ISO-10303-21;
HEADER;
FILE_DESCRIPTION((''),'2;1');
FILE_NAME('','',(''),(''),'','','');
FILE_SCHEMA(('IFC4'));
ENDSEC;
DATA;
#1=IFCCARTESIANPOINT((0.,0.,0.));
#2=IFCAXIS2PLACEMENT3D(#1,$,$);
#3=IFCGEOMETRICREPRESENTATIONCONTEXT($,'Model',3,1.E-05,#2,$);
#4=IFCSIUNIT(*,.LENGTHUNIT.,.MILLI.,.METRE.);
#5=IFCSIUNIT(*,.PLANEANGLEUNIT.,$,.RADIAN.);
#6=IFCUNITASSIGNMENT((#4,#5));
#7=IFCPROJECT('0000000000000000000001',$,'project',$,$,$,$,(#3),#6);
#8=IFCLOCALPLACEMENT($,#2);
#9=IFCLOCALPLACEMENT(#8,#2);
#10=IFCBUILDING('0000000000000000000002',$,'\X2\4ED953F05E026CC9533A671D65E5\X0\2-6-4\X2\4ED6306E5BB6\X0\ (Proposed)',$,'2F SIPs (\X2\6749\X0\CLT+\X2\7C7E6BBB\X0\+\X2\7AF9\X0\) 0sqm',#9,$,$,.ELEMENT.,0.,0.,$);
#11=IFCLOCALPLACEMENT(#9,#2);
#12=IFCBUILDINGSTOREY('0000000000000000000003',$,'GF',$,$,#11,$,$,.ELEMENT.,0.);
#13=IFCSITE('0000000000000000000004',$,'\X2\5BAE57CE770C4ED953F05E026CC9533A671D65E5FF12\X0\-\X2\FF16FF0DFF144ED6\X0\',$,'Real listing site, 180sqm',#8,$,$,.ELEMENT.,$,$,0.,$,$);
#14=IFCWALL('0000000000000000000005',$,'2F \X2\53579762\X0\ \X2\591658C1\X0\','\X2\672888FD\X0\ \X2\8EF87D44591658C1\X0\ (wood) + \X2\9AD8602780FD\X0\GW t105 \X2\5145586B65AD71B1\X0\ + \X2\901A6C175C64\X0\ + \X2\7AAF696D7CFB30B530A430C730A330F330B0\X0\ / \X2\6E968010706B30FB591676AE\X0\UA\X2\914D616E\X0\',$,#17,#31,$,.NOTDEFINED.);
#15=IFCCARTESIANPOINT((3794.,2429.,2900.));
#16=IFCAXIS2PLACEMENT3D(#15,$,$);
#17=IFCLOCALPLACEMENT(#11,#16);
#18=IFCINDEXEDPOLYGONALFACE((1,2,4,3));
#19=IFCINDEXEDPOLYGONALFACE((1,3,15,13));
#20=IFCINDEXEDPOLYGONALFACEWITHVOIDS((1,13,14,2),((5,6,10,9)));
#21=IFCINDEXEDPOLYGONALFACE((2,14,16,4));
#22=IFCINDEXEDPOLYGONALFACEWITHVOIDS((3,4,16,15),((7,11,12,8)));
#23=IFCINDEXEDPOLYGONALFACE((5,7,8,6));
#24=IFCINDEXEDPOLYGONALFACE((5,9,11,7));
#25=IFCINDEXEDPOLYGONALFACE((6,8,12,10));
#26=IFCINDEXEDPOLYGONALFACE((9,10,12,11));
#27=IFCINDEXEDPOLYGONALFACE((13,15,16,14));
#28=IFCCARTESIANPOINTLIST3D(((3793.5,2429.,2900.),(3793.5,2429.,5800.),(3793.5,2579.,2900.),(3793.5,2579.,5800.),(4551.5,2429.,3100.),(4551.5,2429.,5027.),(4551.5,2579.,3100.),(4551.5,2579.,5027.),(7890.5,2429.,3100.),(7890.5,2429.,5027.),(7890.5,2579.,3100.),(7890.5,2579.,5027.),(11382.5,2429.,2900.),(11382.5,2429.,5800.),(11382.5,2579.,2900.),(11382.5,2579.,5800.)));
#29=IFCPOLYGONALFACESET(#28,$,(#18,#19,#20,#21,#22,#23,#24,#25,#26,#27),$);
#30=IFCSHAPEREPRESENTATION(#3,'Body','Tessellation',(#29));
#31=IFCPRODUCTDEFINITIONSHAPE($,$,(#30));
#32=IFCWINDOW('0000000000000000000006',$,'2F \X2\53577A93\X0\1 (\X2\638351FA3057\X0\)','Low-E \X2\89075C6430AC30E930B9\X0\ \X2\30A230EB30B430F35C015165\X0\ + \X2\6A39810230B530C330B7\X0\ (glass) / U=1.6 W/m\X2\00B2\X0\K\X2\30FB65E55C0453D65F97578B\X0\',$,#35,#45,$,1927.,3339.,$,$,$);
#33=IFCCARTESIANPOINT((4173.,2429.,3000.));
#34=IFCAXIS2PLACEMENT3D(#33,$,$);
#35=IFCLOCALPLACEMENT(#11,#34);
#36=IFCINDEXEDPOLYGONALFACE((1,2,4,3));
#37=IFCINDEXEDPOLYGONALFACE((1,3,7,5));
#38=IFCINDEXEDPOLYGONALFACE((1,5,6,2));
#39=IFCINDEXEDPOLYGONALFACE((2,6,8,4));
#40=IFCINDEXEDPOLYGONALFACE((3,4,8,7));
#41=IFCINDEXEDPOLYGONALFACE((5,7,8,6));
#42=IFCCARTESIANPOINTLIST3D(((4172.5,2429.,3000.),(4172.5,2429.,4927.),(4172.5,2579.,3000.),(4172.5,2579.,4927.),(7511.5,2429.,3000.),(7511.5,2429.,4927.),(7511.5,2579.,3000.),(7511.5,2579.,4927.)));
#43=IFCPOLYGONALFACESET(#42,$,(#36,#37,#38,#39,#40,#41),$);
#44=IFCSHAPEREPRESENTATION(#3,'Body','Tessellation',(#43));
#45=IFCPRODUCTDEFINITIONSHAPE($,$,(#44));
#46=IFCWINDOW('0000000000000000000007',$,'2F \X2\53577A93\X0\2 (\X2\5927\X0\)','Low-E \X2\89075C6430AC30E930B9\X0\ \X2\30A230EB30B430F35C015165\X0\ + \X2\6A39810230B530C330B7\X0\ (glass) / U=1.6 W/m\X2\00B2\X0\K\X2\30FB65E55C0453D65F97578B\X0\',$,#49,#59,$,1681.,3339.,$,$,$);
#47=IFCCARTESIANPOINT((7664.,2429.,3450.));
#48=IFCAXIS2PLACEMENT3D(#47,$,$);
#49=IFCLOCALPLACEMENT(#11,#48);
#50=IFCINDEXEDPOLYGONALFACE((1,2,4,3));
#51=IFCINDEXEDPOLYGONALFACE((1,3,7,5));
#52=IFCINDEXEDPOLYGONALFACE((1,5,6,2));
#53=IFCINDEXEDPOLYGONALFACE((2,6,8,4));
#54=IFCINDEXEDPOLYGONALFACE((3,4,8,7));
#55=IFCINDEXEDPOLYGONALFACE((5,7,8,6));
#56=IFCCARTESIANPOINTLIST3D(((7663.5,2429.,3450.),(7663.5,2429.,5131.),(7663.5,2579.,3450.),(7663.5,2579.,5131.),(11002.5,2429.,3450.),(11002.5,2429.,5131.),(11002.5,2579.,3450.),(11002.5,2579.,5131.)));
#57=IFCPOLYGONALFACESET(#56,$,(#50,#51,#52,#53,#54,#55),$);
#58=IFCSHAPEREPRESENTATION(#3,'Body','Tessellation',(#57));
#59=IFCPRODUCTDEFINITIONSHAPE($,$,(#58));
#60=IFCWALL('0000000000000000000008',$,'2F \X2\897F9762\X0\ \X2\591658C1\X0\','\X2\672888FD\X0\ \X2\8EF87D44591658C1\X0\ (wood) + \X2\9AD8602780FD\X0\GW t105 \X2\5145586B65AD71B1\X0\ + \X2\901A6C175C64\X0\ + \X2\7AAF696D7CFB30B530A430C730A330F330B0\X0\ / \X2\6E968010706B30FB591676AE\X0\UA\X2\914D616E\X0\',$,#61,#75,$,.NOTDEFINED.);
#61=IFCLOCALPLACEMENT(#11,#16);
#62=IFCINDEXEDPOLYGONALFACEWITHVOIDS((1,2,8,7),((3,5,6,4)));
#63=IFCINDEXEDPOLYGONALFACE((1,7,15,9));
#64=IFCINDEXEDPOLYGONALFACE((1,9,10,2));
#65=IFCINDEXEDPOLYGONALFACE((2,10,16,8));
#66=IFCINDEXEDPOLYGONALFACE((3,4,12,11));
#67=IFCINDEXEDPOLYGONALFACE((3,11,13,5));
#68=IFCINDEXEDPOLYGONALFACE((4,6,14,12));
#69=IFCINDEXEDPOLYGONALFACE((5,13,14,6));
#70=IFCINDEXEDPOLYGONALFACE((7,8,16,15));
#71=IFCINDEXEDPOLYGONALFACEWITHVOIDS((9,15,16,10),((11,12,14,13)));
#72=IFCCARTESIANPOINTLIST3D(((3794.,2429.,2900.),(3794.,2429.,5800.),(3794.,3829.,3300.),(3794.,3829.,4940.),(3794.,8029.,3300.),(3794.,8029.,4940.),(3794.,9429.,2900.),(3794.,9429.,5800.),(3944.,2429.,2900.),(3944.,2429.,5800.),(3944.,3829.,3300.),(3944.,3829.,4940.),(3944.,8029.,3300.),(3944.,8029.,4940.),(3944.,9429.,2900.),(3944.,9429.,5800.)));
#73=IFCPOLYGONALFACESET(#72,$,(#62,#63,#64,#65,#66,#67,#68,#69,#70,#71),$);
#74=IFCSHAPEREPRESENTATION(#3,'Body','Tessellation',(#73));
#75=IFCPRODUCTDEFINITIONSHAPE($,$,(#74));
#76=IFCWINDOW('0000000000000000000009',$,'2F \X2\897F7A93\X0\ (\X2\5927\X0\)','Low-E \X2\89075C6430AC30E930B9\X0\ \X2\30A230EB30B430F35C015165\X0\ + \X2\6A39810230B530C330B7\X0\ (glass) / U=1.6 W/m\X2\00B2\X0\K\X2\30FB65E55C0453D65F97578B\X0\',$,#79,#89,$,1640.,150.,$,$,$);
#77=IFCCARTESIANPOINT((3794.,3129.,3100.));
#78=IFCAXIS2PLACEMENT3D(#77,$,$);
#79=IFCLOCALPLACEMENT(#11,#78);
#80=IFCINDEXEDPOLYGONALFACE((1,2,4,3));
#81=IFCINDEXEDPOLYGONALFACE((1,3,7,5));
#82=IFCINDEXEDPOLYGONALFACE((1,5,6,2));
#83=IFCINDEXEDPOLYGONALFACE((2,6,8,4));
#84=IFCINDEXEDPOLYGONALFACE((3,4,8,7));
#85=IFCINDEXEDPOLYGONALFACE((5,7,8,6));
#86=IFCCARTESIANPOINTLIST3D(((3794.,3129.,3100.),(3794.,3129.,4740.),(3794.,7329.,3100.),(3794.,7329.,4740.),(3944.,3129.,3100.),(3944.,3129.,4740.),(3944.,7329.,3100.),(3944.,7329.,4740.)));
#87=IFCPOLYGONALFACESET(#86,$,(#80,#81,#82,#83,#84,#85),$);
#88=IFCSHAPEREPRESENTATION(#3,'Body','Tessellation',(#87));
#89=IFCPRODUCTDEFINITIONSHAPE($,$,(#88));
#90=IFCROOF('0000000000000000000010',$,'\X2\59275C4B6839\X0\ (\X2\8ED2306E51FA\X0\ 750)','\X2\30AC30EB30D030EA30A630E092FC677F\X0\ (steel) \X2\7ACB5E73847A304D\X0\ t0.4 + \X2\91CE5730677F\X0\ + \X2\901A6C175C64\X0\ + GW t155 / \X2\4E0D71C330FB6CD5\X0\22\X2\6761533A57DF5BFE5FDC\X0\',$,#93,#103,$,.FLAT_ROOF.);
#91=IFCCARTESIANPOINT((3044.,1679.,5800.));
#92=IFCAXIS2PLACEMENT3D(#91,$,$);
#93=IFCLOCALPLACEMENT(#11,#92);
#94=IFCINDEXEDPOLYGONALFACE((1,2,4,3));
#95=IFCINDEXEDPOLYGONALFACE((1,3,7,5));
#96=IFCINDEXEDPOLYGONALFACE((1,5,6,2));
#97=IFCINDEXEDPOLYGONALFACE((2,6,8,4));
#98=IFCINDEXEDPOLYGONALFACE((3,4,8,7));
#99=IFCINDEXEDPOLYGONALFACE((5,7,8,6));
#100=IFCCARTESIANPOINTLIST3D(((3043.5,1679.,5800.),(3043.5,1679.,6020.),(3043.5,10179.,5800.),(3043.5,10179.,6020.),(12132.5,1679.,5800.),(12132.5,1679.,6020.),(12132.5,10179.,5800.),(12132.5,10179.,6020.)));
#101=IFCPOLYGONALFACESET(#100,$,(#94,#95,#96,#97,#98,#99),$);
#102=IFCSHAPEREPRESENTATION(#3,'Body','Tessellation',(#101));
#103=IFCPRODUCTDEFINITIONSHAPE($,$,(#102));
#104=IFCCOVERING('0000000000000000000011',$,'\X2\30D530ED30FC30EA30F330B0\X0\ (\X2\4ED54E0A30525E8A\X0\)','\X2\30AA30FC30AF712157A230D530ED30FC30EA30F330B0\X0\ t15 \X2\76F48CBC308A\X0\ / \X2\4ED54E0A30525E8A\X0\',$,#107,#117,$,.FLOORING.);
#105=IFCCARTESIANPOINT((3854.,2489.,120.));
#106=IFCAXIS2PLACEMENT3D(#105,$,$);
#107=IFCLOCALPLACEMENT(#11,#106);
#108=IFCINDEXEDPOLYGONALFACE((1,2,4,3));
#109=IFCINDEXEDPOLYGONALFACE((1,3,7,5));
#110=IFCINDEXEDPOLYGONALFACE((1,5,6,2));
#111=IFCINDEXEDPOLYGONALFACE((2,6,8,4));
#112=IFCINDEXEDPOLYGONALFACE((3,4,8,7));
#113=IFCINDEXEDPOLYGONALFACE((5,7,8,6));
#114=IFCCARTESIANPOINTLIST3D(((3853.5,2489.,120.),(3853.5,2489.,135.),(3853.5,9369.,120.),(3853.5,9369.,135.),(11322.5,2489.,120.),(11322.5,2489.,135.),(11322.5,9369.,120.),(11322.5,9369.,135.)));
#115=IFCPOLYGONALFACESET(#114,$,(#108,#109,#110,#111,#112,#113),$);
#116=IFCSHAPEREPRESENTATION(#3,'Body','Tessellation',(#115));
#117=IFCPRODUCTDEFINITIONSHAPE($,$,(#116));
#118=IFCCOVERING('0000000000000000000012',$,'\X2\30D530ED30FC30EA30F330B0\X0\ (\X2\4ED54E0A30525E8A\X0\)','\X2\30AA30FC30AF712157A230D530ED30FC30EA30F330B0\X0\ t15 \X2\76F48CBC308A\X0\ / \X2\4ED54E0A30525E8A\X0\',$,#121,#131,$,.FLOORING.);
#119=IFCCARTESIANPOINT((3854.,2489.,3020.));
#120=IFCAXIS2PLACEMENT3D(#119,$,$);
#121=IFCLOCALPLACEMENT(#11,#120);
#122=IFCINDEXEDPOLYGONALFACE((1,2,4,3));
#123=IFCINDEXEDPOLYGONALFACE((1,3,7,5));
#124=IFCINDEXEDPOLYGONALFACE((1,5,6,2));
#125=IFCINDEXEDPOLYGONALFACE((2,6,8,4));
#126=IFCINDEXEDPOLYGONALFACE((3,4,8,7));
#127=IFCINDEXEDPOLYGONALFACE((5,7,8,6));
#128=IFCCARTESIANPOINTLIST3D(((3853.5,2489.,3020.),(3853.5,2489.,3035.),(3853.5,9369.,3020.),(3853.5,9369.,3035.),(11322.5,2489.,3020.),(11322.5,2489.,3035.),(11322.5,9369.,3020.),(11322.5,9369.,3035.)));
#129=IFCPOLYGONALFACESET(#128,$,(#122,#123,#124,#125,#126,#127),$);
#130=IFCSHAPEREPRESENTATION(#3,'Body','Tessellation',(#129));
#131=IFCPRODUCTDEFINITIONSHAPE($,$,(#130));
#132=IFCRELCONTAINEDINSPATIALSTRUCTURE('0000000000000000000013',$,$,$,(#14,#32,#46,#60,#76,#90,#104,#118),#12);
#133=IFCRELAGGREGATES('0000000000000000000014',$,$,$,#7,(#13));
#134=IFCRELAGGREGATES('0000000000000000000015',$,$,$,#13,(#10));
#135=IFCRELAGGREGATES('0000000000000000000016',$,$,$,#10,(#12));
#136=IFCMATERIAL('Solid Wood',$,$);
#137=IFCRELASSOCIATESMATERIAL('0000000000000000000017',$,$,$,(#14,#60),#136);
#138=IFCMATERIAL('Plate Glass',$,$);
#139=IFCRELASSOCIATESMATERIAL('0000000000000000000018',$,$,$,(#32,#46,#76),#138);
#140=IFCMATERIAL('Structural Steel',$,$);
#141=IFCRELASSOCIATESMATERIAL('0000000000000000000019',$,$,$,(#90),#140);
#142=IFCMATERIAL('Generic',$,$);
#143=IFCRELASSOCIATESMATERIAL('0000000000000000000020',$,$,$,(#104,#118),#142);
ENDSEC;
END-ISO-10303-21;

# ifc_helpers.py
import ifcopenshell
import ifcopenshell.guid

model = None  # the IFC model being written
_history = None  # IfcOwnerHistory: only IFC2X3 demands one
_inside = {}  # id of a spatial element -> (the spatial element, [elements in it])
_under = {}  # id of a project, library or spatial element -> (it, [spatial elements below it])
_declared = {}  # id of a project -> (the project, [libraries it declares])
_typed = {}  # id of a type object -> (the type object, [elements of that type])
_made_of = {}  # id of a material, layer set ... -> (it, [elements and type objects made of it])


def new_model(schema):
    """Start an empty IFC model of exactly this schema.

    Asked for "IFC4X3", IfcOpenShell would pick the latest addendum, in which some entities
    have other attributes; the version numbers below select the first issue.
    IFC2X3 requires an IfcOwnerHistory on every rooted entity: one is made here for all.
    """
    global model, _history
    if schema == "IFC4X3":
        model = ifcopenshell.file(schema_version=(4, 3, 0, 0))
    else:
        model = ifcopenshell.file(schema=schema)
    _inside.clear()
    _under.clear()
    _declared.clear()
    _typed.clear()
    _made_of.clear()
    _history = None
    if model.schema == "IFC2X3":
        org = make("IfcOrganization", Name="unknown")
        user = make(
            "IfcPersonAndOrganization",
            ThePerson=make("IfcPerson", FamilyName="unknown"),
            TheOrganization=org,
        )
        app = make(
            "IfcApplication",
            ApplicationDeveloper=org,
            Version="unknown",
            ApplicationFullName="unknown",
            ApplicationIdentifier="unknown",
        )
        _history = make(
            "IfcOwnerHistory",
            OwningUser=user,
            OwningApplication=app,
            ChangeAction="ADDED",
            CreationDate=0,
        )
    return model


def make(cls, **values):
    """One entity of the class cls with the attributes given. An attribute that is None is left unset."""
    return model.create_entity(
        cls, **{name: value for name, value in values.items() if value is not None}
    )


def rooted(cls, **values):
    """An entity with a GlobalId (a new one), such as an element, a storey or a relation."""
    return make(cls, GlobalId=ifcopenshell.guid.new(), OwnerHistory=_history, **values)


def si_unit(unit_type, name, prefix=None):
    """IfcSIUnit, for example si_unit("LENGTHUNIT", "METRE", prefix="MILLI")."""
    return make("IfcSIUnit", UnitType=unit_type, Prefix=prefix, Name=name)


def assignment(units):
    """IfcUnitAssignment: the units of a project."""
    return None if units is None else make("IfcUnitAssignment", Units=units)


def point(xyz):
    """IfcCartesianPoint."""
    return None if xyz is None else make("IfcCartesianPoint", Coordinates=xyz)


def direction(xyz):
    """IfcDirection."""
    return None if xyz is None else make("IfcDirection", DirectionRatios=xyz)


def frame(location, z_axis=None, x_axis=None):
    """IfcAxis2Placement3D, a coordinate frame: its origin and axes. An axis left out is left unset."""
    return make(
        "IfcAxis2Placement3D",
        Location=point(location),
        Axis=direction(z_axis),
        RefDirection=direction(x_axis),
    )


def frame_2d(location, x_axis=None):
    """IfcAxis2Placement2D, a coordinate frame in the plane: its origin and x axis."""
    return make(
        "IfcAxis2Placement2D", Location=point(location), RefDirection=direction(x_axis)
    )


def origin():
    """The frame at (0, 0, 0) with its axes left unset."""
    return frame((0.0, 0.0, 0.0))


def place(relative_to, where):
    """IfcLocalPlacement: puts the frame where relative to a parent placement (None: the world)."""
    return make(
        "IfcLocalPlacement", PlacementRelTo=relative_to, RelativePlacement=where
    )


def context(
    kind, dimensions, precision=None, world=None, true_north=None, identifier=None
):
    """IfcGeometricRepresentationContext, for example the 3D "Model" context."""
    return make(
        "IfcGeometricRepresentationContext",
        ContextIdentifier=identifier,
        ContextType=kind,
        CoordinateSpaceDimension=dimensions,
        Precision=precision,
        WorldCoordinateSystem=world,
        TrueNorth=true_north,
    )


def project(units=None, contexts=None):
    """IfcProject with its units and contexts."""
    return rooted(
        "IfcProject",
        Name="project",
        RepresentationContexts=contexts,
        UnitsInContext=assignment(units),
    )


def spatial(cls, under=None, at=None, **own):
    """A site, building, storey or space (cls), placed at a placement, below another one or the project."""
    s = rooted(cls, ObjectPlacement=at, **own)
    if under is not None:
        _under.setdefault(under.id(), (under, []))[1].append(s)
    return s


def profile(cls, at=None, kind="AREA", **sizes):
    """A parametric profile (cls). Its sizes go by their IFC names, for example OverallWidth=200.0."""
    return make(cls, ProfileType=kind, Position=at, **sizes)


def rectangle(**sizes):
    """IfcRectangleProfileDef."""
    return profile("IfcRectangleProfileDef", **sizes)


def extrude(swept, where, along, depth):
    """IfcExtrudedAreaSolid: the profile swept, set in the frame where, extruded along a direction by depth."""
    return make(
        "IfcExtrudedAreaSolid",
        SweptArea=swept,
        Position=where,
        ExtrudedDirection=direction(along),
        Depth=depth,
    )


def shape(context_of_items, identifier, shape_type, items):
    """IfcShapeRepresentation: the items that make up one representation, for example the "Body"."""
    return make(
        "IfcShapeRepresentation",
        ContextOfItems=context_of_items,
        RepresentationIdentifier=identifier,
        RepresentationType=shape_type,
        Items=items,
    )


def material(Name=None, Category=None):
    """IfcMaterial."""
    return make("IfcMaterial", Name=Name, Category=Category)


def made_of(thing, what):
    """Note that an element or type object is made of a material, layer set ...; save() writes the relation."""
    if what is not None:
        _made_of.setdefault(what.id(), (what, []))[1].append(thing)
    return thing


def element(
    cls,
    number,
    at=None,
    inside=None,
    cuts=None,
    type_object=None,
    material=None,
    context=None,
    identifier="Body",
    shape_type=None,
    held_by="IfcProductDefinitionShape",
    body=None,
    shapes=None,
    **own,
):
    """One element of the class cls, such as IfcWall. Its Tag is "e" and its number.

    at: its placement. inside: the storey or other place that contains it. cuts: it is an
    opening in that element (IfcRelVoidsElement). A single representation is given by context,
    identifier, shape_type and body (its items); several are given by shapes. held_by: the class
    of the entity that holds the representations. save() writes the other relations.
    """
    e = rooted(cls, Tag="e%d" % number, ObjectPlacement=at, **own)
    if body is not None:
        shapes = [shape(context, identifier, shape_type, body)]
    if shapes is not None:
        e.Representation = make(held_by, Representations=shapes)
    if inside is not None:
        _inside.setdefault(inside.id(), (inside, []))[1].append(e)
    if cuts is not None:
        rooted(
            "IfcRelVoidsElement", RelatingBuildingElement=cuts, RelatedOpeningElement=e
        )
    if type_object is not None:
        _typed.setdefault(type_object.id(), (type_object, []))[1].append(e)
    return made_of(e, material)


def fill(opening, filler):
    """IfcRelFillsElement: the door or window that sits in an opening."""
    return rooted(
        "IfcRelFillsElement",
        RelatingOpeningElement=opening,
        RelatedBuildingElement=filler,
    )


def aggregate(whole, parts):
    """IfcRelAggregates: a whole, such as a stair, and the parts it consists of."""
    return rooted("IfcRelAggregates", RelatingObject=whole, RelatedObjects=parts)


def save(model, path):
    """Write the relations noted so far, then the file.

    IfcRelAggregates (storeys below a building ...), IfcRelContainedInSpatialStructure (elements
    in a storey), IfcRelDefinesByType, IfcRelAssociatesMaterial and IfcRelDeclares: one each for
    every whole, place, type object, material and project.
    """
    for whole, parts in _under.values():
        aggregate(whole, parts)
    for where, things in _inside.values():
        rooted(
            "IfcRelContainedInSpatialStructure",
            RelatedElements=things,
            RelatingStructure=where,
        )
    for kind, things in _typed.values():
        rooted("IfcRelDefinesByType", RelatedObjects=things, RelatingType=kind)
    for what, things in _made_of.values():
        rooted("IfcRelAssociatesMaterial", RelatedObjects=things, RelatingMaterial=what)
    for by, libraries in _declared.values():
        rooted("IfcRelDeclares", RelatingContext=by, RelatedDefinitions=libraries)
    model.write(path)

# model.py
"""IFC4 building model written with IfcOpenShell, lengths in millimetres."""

from ifc_helpers import new_model, si_unit, frame, frame_2d, origin, place, context, project, spatial, rectangle, extrude, material, element, fill, save


model = new_model("IFC4")

# Units and contexts
model_context = context("Model", 3, precision=1e-05, world=origin())
ifc_project = project(units=[si_unit("LENGTHUNIT", "METRE", prefix="MILLI"), si_unit("PLANEANGLEUNIT", "RADIAN")], contexts=[model_context])

# Site, building, storey
site_placement = place(None, origin())
site = spatial("IfcSite", under=ifc_project, at=site_placement, Name="宮城県仙台市泉区朝日２-６－４他", ObjectType="Real listing site, 180sqm", CompositionType="ELEMENT", RefElevation=0.0)
building_placement = place(site_placement, origin())
building = spatial("IfcBuilding", under=site, at=building_placement, Name="仙台市泉区朝日2-6-4他の家 (Proposed)", ObjectType="2F SIPs (杉CLT+籾殻+竹) 0sqm", CompositionType="ELEMENT", ElevationOfRefHeight=0.0, ElevationOfTerrain=0.0)
storey_placement = place(building_placement, origin())
storey = spatial("IfcBuildingStorey", under=building, at=storey_placement, Name="GF", CompositionType="ELEMENT", Elevation=0.0)

# Shared definitions
ifc_material_1 = material(Name="Solid Wood")

# Shared definitions
ifc_material_2 = material(Name="Plate Glass")

# Wall, openings, windows
wall_1_placement = place(storey_placement, frame((3794.0, 2429.0, 2900.0)))
wall_1 = element("IfcWall", 1, at=wall_1_placement, inside=storey, material=ifc_material_1, Name="2F 南面 外壁", Description="木製 軸組外壁 (wood) + 高性能GW t105 充填断熱 + 通気層 + 窯業系サイディング / 準耐火・外皮UA配慮", PredefinedType="NOTDEFINED", context=model_context, shape_type="SweptSolid", body=[
    extrude(rectangle(XDim=7589.0, YDim=150.0, at=frame_2d((3794.0, 75.0))), frame((3794.0, 2429.0, 2900.0)), (0.0, 0.0, 1.0), 2900.0),
])
opening_1_placement = place(storey_placement, frame((4173.0, 2429.0, 3000.0)))
opening_1 = element("IfcOpeningElement", 2, at=opening_1_placement, cuts=wall_1, PredefinedType="NOTDEFINED", context=model_context, shape_type="SweptSolid", body=[
    extrude(rectangle(XDim=3339.0, YDim=150.0, at=frame_2d((1669.0, 75.0))), frame((4173.0, 2429.0, 3000.0)), (0.0, 0.0, 1.0), 1927.0),
])
opening_2_placement = place(storey_placement, frame((7664.0, 2429.0, 3450.0)))
opening_2 = element("IfcOpeningElement", 3, at=opening_2_placement, cuts=wall_1, PredefinedType="NOTDEFINED", context=model_context, shape_type="SweptSolid", body=[
    extrude(rectangle(XDim=3339.0, YDim=150.0, at=frame_2d((1669.0, 75.0))), frame((7664.0, 2429.0, 3450.0)), (0.0, 0.0, 1.0), 1681.0),
])
window_1_placement = place(storey_placement, frame((4173.0, 2429.0, 3000.0)))
window_1 = element("IfcWindow", 4, at=window_1_placement, inside=storey, material=ifc_material_2, Name="2F 南窓1 (掃出し)", Description="Low-E 複層ガラス アルゴン封入 + 樹脂サッシ (glass) / U=1.6 W/m²K・日射取得型", OverallHeight=1927.0, OverallWidth=3339.0, context=model_context, shape_type="SweptSolid", body=[
    extrude(rectangle(XDim=3339.0, YDim=150.0, at=frame_2d((1669.0, 75.0))), frame((4173.0, 2429.0, 3000.0)), (0.0, 0.0, 1.0), 1927.0),
])
fill(opening_1, window_1)
window_2_placement = place(storey_placement, frame((7664.0, 2429.0, 3450.0)))
window_2 = element("IfcWindow", 5, at=window_2_placement, inside=storey, material=ifc_material_2, Name="2F 南窓2 (大)", Description="Low-E 複層ガラス アルゴン封入 + 樹脂サッシ (glass) / U=1.6 W/m²K・日射取得型", OverallHeight=1681.0, OverallWidth=3339.0, context=model_context, shape_type="SweptSolid", body=[
    extrude(rectangle(XDim=3339.0, YDim=150.0, at=frame_2d((1669.0, 75.0))), frame((7664.0, 2429.0, 3450.0)), (0.0, 0.0, 1.0), 1681.0),
])
fill(opening_2, window_2)

# Wall, opening, window
wall_2_placement = place(storey_placement, frame((3794.0, 2429.0, 2900.0)))
wall_2 = element("IfcWall", 6, at=wall_2_placement, inside=storey, material=ifc_material_1, Name="2F 西面 外壁", Description="木製 軸組外壁 (wood) + 高性能GW t105 充填断熱 + 通気層 + 窯業系サイディング / 準耐火・外皮UA配慮", PredefinedType="NOTDEFINED", context=model_context, shape_type="SweptSolid", body=[
    extrude(rectangle(XDim=150.0, YDim=7000.0, at=frame_2d((75.0, 3500.0))), frame((3794.0, 2429.0, 2900.0)), (0.0, 0.0, 1.0), 2900.0),
])
opening_3_placement = place(storey_placement, frame((3794.0, 3129.0, 3100.0)))
opening_3 = element("IfcOpeningElement", 7, at=opening_3_placement, cuts=wall_2, PredefinedType="NOTDEFINED", context=model_context, shape_type="SweptSolid", body=[
    extrude(rectangle(XDim=150.0, YDim=4200.0, at=frame_2d((75.0, 2100.0))), frame((3794.0, 3129.0, 3100.0)), (0.0, 0.0, 1.0), 1640.0),
])
window_3_placement = place(storey_placement, frame((3794.0, 3129.0, 3100.0)))
window_3 = element("IfcWindow", 8, at=window_3_placement, inside=storey, material=ifc_material_2, Name="2F 西窓 (大)", Description="Low-E 複層ガラス アルゴン封入 + 樹脂サッシ (glass) / U=1.6 W/m²K・日射取得型", OverallHeight=1640.0, OverallWidth=150.0, context=model_context, shape_type="SweptSolid", body=[
    extrude(rectangle(XDim=150.0, YDim=4200.0, at=frame_2d((75.0, 2100.0))), frame((3794.0, 3129.0, 3100.0)), (0.0, 0.0, 1.0), 1640.0),
])
fill(opening_3, window_3)

# Roof
ifc_material_3 = material(Name="Structural Steel")
roof_placement = place(storey_placement, frame((3044.0, 1679.0, 5800.0)))
element("IfcRoof", 9, at=roof_placement, inside=storey, material=ifc_material_3, Name="大屋根 (軒の出 750)", Description="ガルバリウム鋼板 (steel) 立平葺き t0.4 + 野地板 + 通気層 + GW t155 / 不燃・法22条区域対応", PredefinedType="FLAT_ROOF", context=model_context, shape_type="SweptSolid", body=[
    extrude(rectangle(XDim=9089.0, YDim=8500.0, at=frame_2d((4544.0, 4250.0))), frame((3044.0, 1679.0, 5800.0)), (0.0, 0.0, 1.0), 220.0),
])

# Coverings
ifc_material_4 = material(Name="Generic")
covering_1_placement = place(storey_placement, frame((3854.0, 2489.0, 120.0)))
element("IfcCovering", 10, at=covering_1_placement, inside=storey, material=ifc_material_4, Name="フローリング (仕上げ床)", Description="オーク無垢フローリング t15 直貼り / 仕上げ床", PredefinedType="FLOORING", context=model_context, shape_type="SweptSolid", body=[
    extrude(rectangle(XDim=7469.0, YDim=6880.0, at=frame_2d((3734.0, 3440.0))), frame((3854.0, 2489.0, 120.0)), (0.0, 0.0, 1.0), 15.0),
])
covering_2_placement = place(storey_placement, frame((3854.0, 2489.0, 3020.0)))
element("IfcCovering", 11, at=covering_2_placement, inside=storey, material=ifc_material_4, Name="フローリング (仕上げ床)", Description="オーク無垢フローリング t15 直貼り / 仕上げ床", PredefinedType="FLOORING", context=model_context, shape_type="SweptSolid", body=[
    extrude(rectangle(XDim=7469.0, YDim=6880.0, at=frame_2d((3734.0, 3440.0))), frame((3854.0, 2489.0, 3020.0)), (0.0, 0.0, 1.0), 15.0),
])

save(model, "model.ifc")
